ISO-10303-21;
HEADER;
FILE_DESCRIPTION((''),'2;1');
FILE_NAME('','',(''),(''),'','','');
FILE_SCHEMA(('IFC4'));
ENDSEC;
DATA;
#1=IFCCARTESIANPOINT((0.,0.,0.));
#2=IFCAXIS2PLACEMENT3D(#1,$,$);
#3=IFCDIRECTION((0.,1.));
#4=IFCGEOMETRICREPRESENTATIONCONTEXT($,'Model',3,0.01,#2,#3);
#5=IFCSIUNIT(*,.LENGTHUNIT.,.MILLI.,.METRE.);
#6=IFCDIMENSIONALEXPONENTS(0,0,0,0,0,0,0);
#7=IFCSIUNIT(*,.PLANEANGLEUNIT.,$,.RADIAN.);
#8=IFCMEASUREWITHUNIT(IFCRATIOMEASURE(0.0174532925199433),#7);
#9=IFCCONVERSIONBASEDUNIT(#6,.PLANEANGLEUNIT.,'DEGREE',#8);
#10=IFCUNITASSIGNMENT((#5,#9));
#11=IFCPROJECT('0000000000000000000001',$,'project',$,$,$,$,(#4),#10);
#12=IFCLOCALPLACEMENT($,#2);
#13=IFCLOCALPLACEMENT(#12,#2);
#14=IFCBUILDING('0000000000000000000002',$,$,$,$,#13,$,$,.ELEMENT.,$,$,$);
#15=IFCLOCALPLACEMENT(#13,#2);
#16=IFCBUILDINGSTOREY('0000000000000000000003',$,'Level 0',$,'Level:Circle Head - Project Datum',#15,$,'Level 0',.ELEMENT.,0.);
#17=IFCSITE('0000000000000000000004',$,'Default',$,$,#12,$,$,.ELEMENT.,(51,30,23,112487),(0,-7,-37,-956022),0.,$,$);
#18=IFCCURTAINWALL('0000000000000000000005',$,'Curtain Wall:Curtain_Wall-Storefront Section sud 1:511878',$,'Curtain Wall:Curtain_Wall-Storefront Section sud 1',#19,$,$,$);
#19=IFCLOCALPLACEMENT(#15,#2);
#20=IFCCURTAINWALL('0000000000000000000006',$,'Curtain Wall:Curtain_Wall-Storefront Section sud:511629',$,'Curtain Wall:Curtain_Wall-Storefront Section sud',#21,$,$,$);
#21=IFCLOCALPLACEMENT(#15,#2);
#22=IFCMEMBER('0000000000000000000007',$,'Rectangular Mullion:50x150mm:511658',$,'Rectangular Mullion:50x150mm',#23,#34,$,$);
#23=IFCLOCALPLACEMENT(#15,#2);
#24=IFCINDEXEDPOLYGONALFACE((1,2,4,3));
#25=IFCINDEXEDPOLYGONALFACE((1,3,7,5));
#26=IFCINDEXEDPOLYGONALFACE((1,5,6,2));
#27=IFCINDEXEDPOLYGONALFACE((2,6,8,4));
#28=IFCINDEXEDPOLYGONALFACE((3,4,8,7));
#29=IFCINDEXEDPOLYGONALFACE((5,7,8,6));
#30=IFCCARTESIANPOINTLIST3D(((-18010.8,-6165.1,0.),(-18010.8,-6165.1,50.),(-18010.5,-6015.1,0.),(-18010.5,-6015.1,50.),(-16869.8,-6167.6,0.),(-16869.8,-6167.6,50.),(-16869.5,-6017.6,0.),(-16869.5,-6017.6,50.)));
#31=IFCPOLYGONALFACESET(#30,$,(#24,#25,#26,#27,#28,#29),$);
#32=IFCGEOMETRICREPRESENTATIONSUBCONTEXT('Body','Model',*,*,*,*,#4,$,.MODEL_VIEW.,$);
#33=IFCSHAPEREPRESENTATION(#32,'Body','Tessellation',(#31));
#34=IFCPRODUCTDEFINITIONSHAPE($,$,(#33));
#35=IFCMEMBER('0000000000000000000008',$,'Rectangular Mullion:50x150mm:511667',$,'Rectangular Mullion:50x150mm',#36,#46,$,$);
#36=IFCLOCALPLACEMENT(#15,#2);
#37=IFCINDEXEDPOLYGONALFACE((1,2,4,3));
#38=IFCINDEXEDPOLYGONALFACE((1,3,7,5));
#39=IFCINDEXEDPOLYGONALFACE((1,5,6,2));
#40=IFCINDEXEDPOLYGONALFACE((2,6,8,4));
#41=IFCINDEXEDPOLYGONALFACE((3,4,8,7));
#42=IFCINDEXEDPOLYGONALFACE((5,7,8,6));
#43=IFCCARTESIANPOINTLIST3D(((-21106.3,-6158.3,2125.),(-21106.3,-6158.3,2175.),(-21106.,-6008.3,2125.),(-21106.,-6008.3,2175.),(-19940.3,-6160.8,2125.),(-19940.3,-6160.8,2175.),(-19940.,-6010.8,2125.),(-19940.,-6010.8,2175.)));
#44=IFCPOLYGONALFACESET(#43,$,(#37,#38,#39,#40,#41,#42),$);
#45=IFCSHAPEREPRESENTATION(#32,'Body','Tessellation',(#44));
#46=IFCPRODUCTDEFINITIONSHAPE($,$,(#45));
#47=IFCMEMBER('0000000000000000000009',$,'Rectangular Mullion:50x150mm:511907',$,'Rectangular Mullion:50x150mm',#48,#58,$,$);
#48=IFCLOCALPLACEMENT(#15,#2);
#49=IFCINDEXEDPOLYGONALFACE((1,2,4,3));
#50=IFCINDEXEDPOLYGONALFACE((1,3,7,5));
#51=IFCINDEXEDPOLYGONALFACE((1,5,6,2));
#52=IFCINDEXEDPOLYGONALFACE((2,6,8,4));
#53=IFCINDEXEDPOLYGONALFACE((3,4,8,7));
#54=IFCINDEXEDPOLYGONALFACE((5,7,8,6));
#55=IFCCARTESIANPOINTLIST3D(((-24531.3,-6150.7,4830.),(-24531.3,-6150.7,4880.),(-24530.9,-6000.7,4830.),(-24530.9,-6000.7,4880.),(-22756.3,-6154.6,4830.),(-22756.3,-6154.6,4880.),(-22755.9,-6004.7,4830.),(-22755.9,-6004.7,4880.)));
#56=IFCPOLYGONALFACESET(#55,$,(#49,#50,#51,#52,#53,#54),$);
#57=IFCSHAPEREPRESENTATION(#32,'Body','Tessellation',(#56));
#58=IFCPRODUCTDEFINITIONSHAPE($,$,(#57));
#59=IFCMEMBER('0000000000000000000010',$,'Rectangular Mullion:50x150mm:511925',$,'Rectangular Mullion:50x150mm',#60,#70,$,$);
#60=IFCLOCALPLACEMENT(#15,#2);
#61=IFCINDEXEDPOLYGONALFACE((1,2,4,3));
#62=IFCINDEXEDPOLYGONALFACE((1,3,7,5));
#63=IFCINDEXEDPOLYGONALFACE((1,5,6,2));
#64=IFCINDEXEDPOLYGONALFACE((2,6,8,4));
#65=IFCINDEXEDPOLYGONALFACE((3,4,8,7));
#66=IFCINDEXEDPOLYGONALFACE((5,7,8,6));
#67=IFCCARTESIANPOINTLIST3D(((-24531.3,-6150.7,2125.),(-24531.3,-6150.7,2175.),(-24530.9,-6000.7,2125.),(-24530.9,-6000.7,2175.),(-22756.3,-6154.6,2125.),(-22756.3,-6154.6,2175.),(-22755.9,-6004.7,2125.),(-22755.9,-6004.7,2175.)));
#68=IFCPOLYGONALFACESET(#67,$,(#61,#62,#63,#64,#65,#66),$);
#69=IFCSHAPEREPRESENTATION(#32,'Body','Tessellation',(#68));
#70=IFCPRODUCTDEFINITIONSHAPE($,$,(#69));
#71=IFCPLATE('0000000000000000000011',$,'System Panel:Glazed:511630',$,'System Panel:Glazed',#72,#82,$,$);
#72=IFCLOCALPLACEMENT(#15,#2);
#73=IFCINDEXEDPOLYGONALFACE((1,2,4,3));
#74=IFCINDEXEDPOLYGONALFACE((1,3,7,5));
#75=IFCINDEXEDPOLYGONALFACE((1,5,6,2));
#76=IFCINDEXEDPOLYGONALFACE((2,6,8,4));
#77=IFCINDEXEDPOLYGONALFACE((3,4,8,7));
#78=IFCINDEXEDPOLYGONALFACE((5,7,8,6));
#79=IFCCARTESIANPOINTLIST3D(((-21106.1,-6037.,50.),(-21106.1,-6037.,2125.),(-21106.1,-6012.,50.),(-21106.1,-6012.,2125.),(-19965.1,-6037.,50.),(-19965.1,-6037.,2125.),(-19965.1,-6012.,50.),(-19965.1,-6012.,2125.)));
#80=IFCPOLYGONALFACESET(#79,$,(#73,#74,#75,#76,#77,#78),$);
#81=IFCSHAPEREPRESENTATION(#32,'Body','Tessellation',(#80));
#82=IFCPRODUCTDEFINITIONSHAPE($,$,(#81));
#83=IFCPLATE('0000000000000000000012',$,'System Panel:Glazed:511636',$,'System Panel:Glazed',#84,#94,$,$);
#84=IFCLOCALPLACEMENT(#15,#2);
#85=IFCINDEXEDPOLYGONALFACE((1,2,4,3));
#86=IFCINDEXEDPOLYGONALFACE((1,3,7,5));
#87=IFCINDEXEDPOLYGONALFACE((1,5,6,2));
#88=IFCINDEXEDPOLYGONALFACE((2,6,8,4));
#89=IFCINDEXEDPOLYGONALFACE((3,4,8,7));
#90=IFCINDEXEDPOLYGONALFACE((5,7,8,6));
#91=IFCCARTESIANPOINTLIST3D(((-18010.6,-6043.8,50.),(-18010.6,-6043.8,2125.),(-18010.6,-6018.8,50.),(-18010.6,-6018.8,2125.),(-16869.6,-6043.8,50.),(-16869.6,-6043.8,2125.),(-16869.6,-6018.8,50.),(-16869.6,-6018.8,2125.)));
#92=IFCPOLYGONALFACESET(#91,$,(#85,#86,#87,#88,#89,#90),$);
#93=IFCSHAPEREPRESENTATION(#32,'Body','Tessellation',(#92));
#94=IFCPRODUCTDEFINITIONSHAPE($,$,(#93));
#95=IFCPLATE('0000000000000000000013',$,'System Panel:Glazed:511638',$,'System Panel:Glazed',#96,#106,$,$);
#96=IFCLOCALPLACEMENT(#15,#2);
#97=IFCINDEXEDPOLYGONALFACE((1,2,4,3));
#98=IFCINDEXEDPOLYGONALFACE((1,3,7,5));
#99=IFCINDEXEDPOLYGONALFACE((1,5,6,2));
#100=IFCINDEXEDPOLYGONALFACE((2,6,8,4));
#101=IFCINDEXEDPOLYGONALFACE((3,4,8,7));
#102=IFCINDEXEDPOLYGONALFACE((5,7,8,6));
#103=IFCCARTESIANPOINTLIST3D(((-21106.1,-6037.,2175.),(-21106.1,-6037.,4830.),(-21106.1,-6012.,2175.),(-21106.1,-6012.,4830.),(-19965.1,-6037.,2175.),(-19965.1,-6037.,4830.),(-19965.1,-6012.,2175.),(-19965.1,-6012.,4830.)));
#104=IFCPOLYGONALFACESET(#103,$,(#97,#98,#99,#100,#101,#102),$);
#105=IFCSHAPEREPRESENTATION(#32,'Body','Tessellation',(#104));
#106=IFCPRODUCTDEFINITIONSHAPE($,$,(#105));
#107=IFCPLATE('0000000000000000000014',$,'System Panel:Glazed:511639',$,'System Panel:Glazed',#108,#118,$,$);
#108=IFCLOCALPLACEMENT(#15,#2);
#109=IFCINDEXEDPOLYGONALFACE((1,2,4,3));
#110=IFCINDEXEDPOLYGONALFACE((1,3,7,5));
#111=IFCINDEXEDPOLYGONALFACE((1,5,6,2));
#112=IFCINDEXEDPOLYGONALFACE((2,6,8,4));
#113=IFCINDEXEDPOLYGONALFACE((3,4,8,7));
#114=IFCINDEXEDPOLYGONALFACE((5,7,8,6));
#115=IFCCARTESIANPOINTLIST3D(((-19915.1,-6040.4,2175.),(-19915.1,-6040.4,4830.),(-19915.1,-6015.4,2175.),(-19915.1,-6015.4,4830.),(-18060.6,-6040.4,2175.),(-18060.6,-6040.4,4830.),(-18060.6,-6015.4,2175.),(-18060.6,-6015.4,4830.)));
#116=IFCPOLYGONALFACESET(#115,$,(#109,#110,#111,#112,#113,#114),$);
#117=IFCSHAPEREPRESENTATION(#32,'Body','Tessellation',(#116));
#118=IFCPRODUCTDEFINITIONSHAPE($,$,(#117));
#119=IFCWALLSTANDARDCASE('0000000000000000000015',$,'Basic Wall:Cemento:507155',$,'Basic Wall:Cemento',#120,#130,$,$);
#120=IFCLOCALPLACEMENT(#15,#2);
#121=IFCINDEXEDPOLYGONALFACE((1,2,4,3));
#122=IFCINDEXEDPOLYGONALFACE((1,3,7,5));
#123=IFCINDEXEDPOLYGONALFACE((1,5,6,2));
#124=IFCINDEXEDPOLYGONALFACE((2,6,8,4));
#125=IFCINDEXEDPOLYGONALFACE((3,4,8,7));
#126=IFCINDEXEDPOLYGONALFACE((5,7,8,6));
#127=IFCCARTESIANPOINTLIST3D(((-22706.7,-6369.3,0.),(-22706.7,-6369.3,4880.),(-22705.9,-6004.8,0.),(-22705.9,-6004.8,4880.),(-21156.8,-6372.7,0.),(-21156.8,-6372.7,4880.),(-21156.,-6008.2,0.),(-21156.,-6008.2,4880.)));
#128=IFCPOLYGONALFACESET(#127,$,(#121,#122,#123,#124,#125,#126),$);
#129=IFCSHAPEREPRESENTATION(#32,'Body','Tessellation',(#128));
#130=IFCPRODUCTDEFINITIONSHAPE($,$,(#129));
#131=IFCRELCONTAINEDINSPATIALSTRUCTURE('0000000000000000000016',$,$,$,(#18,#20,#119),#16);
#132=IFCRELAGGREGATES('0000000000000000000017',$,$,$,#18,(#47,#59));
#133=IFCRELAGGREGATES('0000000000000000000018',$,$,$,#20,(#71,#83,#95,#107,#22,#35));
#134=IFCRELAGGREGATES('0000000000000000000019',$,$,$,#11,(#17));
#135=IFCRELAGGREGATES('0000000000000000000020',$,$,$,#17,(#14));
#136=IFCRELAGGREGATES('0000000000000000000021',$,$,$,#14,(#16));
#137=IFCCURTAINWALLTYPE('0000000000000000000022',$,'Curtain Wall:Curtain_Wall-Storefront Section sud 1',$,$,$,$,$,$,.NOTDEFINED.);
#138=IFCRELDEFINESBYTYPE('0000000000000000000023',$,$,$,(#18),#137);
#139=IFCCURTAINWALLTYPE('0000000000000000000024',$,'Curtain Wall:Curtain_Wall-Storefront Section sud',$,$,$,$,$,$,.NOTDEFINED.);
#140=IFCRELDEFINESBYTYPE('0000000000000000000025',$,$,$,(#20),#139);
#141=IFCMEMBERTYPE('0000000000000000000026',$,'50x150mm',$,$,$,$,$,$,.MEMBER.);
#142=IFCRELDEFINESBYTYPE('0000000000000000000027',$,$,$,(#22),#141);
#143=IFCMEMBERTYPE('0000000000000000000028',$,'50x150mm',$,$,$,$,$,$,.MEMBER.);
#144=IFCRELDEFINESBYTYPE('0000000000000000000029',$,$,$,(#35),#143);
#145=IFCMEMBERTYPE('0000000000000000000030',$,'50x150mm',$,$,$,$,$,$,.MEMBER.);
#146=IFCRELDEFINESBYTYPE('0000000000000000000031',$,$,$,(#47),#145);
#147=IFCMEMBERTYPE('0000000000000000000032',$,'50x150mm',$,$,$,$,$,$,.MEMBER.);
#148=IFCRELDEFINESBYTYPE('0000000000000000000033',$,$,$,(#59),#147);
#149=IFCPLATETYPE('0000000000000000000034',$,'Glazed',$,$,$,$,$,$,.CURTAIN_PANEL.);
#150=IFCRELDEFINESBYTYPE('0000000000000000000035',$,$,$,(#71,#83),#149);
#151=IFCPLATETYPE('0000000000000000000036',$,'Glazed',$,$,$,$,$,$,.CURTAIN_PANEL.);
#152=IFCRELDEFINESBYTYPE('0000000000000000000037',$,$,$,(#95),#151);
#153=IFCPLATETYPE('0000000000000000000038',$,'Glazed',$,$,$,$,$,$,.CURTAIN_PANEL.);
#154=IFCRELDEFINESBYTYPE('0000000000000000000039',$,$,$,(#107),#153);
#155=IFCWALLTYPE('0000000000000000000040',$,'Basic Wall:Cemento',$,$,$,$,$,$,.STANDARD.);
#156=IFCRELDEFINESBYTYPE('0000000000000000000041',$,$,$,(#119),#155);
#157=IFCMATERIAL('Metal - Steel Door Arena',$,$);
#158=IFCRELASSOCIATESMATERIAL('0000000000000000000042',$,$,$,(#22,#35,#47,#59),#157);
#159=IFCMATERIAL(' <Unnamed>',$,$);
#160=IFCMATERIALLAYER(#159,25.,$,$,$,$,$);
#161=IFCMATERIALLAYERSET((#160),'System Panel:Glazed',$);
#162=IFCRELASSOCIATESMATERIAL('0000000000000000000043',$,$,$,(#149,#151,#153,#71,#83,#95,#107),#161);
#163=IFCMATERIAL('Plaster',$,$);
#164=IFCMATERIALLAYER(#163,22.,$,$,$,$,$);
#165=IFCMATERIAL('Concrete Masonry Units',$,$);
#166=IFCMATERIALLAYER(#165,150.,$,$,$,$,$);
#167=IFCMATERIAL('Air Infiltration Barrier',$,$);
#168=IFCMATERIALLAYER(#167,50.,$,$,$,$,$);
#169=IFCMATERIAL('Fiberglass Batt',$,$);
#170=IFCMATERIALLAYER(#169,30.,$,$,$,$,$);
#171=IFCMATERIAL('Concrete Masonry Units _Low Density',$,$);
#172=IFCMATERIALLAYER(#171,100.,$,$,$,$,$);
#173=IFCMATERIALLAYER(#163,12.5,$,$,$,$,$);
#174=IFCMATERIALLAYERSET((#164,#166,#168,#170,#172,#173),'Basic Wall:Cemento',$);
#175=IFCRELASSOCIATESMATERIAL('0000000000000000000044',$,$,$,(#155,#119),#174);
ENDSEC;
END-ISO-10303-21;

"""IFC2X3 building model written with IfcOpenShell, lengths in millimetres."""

from ifc_helpers import new_model, entity, si_unit, converted_unit, direction, frame, frame_2d, origin, origin_2d_with_axis, place, context, subcontext, project, spatial, rectangle, extrude, source, transform, mapped, material, layer, layer_set, layer_usage, type_object, type_shapes, element, aggregate, save


model = new_model("IFC2X3")

# Units and contexts
model_context = context("Model", 3, precision=0.01, world=origin(), true_north=direction((0.0, 1.0)))
body_context = subcontext(model_context, "Body", "Model", "MODEL_VIEW")
ifc_project = project(units=[si_unit("LENGTHUNIT", "METRE", prefix="MILLI"), converted_unit("PLANEANGLEUNIT", "DEGREE", entity("IfcRatioMeasure", 0.0174532925199433), si_unit("PLANEANGLEUNIT", "RADIAN"), dimensions=[0, 0, 0, 0, 0, 0, 0])], contexts=[model_context])

# Site, building, storey
site_placement = place(None, origin())
site = spatial("IfcSite", under=ifc_project, at=site_placement, Name="Default", CompositionType="ELEMENT", RefLatitude=(51, 30, 23, 112487), RefLongitude=(0, -7, -37, -956022), RefElevation=0.0)
building_placement = place(site_placement, origin())
building = spatial("IfcBuilding", under=site, at=building_placement, CompositionType="ELEMENT")
storey_placement = place(building_placement, origin())
storey = spatial("IfcBuildingStorey", under=building, at=storey_placement, Name="Level 0", ObjectType="Level:Circle Head - Project Datum", LongName="Level 0", CompositionType="ELEMENT", Elevation=0.0)

# Curtain wall
curtain_wall_type_1 = type_object("IfcCurtainWallType", Name="Curtain Wall:Curtain_Wall-Storefront Section sud 1", PredefinedType="NOTDEFINED")
curtain_wall_1_placement = place(storey_placement, origin())
curtain_wall_1 = element("IfcCurtainWall", 1, at=curtain_wall_1_placement, inside=storey, type_object=curtain_wall_type_1, Name="Curtain Wall:Curtain_Wall-Storefront Section sud 1:511878", ObjectType="Curtain Wall:Curtain_Wall-Storefront Section sud 1")
ifc_material_1 = material(Name="Metal - Steel Door Arena")

# Curtain wall
curtain_wall_type_2 = type_object("IfcCurtainWallType", Name="Curtain Wall:Curtain_Wall-Storefront Section sud", PredefinedType="NOTDEFINED")
curtain_wall_2_placement = place(storey_placement, origin())
curtain_wall_2 = element("IfcCurtainWall", 2, at=curtain_wall_2_placement, inside=storey, type_object=curtain_wall_type_2, Name="Curtain Wall:Curtain_Wall-Storefront Section sud:511629", ObjectType="Curtain Wall:Curtain_Wall-Storefront Section sud")

# Members
member_type_1 = type_object("IfcMemberType", Name="50x150mm", PredefinedType="MEMBER")
shared_shape_1 = source(origin(), body_context, "Body", "SweptSolid", [
    extrude(rectangle(XDim=150.0, YDim=50.0, at=origin_2d_with_axis()), frame((-25.0, 0.0, -1141.0), z_axis=(0.0, 0.0, 1.0), x_axis=(0.0, -1.0, 0.0)), (0.0, 0.0, 1.0), 1141.0),
])
type_shapes(member_type_1, [shared_shape_1])
member_1_placement = place(storey_placement, frame((-18010.6, -6090.1, 0.0), z_axis=(-0.999998, 0.002199, 0.0), x_axis=(0.0, 0.0, -1.0)))
member_1 = element("IfcMember", 3, at=member_1_placement, type_object=member_type_1, material=ifc_material_1, Name="Rectangular Mullion:50x150mm:511658", ObjectType="Rectangular Mullion:50x150mm", context=body_context, shape_type="MappedRepresentation", body=[
    mapped(shared_shape_1, transform((0.0, 0.0, 0.0), scale=1.0)),
])
member_type_2 = type_object("IfcMemberType", Name="50x150mm", PredefinedType="MEMBER")
shared_shape_2 = source(origin(), body_context, "Body", "SweptSolid", [
    extrude(rectangle(XDim=150.0, YDim=50.0, at=origin_2d_with_axis()), frame((0.0, 0.0, -1166.0), z_axis=(0.0, 0.0, 1.0), x_axis=(0.0, -1.0, 0.0)), (0.0, 0.0, 1.0), 1166.0),
])
type_shapes(member_type_2, [shared_shape_2])
member_2_placement = place(storey_placement, frame((-19940.1, -6085.8, 2150.0), z_axis=(0.999998, -0.002199, 0.0), x_axis=(0.0, 0.0, 1.0)))
member_2 = element("IfcMember", 4, at=member_2_placement, type_object=member_type_2, material=ifc_material_1, Name="Rectangular Mullion:50x150mm:511667", ObjectType="Rectangular Mullion:50x150mm", context=body_context, shape_type="MappedRepresentation", body=[
    mapped(shared_shape_2, transform((0.0, 0.0, 0.0), scale=1.0)),
])
member_type_3 = type_object("IfcMemberType", Name="50x150mm", PredefinedType="MEMBER")
shared_shape_3 = source(origin(), body_context, "Body", "SweptSolid", [
    extrude(rectangle(XDim=150.0, YDim=50.0, at=origin_2d_with_axis()), frame((-25.0, 0.0, -1775.0), z_axis=(0.0, 0.0, 1.0), x_axis=(0.0, -1.0, 0.0)), (0.0, 0.0, 1.0), 1775.0),
])
type_shapes(member_type_3, [shared_shape_3])
member_3_placement = place(storey_placement, frame((-22756.1, -6079.7, 4880.0), z_axis=(0.999998, -0.002199, 0.0), x_axis=(0.0, 0.0, 1.0)))
member_3 = element("IfcMember", 5, at=member_3_placement, type_object=member_type_3, material=ifc_material_1, Name="Rectangular Mullion:50x150mm:511907", ObjectType="Rectangular Mullion:50x150mm", context=body_context, shape_type="MappedRepresentation", body=[
    mapped(shared_shape_3, transform((0.0, 0.0, 0.0), scale=1.0)),
])
member_type_4 = type_object("IfcMemberType", Name="50x150mm", PredefinedType="MEMBER")
shared_shape_4 = source(origin(), body_context, "Body", "SweptSolid", [
    extrude(rectangle(XDim=150.0, YDim=50.0, at=origin_2d_with_axis()), frame((0.0, 0.0, -1775.0), z_axis=(0.0, 0.0, 1.0), x_axis=(0.0, -1.0, 0.0)), (0.0, 0.0, 1.0), 1775.0),
])
type_shapes(member_type_4, [shared_shape_4])
member_4_placement = place(storey_placement, frame((-22756.1, -6079.7, 2150.0), z_axis=(0.999998, -0.002199, 0.0), x_axis=(0.0, 0.0, 1.0)))
member_4 = element("IfcMember", 6, at=member_4_placement, type_object=member_type_4, material=ifc_material_1, Name="Rectangular Mullion:50x150mm:511925", ObjectType="Rectangular Mullion:50x150mm", context=body_context, shape_type="MappedRepresentation", body=[
    mapped(shared_shape_4, transform((0.0, 0.0, 0.0), scale=1.0)),
])
aggregate(curtain_wall_1, [member_3, member_4])

# Plates
ifc_material_2 = material(Name=" <Unnamed>")
ifc_layer_1 = layer(ifc_material_2, 25.0)
ifc_layer_set_1 = layer_set([ifc_layer_1], Name="System Panel:Glazed")
ifc_layer_usage_1 = layer_usage(ifc_layer_set_1, "AXIS3", "POSITIVE", 0.2)
plate_type_1 = type_object("IfcPlateType", Name="Glazed", PredefinedType="CURTAIN_PANEL", material=ifc_layer_set_1)
shared_shape_5 = source(origin(), body_context, "Body", "SweptSolid", [
    extrude(rectangle(XDim=25.0, YDim=1141.0, at=origin_2d_with_axis()), frame((0.0, 60.0, 0.0), z_axis=(0.0, 0.0, 1.0), x_axis=(0.0, 1.0, 0.0)), (0.0, 0.0, 1.0), 2075.0),
])
type_shapes(plate_type_1, [shared_shape_5])
plate_1_placement = place(curtain_wall_2_placement, frame((-20535.6, -6084.5, 50.0)))
plate_1 = element("IfcPlate", 7, at=plate_1_placement, type_object=plate_type_1, material=ifc_layer_usage_1, Name="System Panel:Glazed:511630", ObjectType="System Panel:Glazed", context=body_context, shape_type="MappedRepresentation", body=[
    mapped(shared_shape_5, transform((0.0, 0.0, 0.0), scale=1.0)),
])
ifc_layer_usage_2 = layer_usage(ifc_layer_set_1, "AXIS3", "POSITIVE", 0.2)
plate_2_placement = place(curtain_wall_2_placement, frame((-17440.1, -6091.3, 50.0)))
plate_2 = element("IfcPlate", 8, at=plate_2_placement, type_object=plate_type_1, material=ifc_layer_usage_2, Name="System Panel:Glazed:511636", ObjectType="System Panel:Glazed", context=body_context, shape_type="MappedRepresentation", body=[
    mapped(shared_shape_5, transform((0.0, 0.0, 0.0), scale=1.0)),
])
ifc_layer_usage_3 = layer_usage(ifc_layer_set_1, "AXIS3", "POSITIVE", 0.2)
plate_type_2 = type_object("IfcPlateType", Name="Glazed", PredefinedType="CURTAIN_PANEL", material=ifc_layer_set_1)
shared_shape_6 = source(origin(), body_context, "Body", "SweptSolid", [
    extrude(rectangle(XDim=25.0, YDim=1141.0, at=frame_2d((0.0, 0.0), x_axis=(1.0, 0.0))), frame((0.0, 60.0, 0.0), z_axis=(0.0, 0.0, 1.0), x_axis=(0.0, 1.0, 0.0)), (0.0, 0.0, 1.0), 2655.0),
])
type_shapes(plate_type_2, [shared_shape_6])
plate_3_placement = place(curtain_wall_2_placement, frame((-20535.6, -6084.5, 2175.0)))
plate_3 = element("IfcPlate", 9, at=plate_3_placement, type_object=plate_type_2, material=ifc_layer_usage_3, Name="System Panel:Glazed:511638", ObjectType="System Panel:Glazed", context=body_context, shape_type="MappedRepresentation", body=[
    mapped(shared_shape_6, transform((0.0, 0.0, 0.0), scale=1.0)),
])
ifc_layer_usage_4 = layer_usage(ifc_layer_set_1, "AXIS3", "POSITIVE", 0.2)
plate_type_3 = type_object("IfcPlateType", Name="Glazed", PredefinedType="CURTAIN_PANEL", material=ifc_layer_set_1)
shared_shape_7 = source(origin(), body_context, "Body", "SweptSolid", [
    extrude(rectangle(XDim=25.0, YDim=1854.5, at=frame_2d((0.0, 0.0), x_axis=(1.0, 0.0))), frame((0.0, 60.0, 0.0), z_axis=(0.0, 0.0, 1.0), x_axis=(0.0, 1.0, 0.0)), (0.0, 0.0, 1.0), 2655.0),
])
type_shapes(plate_type_3, [shared_shape_7])
plate_4_placement = place(curtain_wall_2_placement, frame((-18987.9, -6087.9, 2175.0)))
plate_4 = element("IfcPlate", 10, at=plate_4_placement, type_object=plate_type_3, material=ifc_layer_usage_4, Name="System Panel:Glazed:511639", ObjectType="System Panel:Glazed", context=body_context, shape_type="MappedRepresentation", body=[
    mapped(shared_shape_7, transform((0.0, 0.0, 0.0), scale=1.0)),
])
aggregate(curtain_wall_2, [plate_1, plate_2, plate_3, plate_4, member_1, member_2])

# Wall
ifc_material_3 = material(Name="Plaster")
ifc_layer_2 = layer(ifc_material_3, 22.0)
ifc_material_4 = material(Name="Concrete Masonry Units")
ifc_layer_3 = layer(ifc_material_4, 150.0)
ifc_material_5 = material(Name="Air Infiltration Barrier")
ifc_layer_4 = layer(ifc_material_5, 50.0)
ifc_material_6 = material(Name="Fiberglass Batt")
ifc_layer_5 = layer(ifc_material_6, 30.0)
ifc_material_7 = material(Name="Concrete Masonry Units _Low Density")
ifc_layer_6 = layer(ifc_material_7, 100.0)
ifc_layer_7 = layer(ifc_material_3, 12.5)
ifc_layer_set_2 = layer_set([ifc_layer_2, ifc_layer_3, ifc_layer_4, ifc_layer_5, ifc_layer_6, ifc_layer_7], Name="Basic Wall:Cemento")
ifc_layer_usage_5 = layer_usage(ifc_layer_set_2, "AXIS2", "NEGATIVE", 182.2)
wall_type = type_object("IfcWallType", Name="Basic Wall:Cemento", PredefinedType="STANDARD", material=ifc_layer_set_2)
wall_placement = place(storey_placement, frame((-21156.4, -6190.4, 0.0), z_axis=(0.0, 0.0, 1.0), x_axis=(-0.999998, 0.002199, 0.0)))
element("IfcWallStandardCase", 11, at=wall_placement, inside=storey, type_object=wall_type, material=ifc_layer_usage_5, Name="Basic Wall:Cemento:507155", ObjectType="Basic Wall:Cemento", context=body_context, shape_type="SweptSolid", body=[
    extrude(rectangle(XDim=1550.0, YDim=364.5, at=frame_2d((775.0, 0.0), x_axis=(-1.0, 0.0))), origin(), (0.0, 0.0, 1.0), 4880.0),
])

save(model, "model.ifc")
